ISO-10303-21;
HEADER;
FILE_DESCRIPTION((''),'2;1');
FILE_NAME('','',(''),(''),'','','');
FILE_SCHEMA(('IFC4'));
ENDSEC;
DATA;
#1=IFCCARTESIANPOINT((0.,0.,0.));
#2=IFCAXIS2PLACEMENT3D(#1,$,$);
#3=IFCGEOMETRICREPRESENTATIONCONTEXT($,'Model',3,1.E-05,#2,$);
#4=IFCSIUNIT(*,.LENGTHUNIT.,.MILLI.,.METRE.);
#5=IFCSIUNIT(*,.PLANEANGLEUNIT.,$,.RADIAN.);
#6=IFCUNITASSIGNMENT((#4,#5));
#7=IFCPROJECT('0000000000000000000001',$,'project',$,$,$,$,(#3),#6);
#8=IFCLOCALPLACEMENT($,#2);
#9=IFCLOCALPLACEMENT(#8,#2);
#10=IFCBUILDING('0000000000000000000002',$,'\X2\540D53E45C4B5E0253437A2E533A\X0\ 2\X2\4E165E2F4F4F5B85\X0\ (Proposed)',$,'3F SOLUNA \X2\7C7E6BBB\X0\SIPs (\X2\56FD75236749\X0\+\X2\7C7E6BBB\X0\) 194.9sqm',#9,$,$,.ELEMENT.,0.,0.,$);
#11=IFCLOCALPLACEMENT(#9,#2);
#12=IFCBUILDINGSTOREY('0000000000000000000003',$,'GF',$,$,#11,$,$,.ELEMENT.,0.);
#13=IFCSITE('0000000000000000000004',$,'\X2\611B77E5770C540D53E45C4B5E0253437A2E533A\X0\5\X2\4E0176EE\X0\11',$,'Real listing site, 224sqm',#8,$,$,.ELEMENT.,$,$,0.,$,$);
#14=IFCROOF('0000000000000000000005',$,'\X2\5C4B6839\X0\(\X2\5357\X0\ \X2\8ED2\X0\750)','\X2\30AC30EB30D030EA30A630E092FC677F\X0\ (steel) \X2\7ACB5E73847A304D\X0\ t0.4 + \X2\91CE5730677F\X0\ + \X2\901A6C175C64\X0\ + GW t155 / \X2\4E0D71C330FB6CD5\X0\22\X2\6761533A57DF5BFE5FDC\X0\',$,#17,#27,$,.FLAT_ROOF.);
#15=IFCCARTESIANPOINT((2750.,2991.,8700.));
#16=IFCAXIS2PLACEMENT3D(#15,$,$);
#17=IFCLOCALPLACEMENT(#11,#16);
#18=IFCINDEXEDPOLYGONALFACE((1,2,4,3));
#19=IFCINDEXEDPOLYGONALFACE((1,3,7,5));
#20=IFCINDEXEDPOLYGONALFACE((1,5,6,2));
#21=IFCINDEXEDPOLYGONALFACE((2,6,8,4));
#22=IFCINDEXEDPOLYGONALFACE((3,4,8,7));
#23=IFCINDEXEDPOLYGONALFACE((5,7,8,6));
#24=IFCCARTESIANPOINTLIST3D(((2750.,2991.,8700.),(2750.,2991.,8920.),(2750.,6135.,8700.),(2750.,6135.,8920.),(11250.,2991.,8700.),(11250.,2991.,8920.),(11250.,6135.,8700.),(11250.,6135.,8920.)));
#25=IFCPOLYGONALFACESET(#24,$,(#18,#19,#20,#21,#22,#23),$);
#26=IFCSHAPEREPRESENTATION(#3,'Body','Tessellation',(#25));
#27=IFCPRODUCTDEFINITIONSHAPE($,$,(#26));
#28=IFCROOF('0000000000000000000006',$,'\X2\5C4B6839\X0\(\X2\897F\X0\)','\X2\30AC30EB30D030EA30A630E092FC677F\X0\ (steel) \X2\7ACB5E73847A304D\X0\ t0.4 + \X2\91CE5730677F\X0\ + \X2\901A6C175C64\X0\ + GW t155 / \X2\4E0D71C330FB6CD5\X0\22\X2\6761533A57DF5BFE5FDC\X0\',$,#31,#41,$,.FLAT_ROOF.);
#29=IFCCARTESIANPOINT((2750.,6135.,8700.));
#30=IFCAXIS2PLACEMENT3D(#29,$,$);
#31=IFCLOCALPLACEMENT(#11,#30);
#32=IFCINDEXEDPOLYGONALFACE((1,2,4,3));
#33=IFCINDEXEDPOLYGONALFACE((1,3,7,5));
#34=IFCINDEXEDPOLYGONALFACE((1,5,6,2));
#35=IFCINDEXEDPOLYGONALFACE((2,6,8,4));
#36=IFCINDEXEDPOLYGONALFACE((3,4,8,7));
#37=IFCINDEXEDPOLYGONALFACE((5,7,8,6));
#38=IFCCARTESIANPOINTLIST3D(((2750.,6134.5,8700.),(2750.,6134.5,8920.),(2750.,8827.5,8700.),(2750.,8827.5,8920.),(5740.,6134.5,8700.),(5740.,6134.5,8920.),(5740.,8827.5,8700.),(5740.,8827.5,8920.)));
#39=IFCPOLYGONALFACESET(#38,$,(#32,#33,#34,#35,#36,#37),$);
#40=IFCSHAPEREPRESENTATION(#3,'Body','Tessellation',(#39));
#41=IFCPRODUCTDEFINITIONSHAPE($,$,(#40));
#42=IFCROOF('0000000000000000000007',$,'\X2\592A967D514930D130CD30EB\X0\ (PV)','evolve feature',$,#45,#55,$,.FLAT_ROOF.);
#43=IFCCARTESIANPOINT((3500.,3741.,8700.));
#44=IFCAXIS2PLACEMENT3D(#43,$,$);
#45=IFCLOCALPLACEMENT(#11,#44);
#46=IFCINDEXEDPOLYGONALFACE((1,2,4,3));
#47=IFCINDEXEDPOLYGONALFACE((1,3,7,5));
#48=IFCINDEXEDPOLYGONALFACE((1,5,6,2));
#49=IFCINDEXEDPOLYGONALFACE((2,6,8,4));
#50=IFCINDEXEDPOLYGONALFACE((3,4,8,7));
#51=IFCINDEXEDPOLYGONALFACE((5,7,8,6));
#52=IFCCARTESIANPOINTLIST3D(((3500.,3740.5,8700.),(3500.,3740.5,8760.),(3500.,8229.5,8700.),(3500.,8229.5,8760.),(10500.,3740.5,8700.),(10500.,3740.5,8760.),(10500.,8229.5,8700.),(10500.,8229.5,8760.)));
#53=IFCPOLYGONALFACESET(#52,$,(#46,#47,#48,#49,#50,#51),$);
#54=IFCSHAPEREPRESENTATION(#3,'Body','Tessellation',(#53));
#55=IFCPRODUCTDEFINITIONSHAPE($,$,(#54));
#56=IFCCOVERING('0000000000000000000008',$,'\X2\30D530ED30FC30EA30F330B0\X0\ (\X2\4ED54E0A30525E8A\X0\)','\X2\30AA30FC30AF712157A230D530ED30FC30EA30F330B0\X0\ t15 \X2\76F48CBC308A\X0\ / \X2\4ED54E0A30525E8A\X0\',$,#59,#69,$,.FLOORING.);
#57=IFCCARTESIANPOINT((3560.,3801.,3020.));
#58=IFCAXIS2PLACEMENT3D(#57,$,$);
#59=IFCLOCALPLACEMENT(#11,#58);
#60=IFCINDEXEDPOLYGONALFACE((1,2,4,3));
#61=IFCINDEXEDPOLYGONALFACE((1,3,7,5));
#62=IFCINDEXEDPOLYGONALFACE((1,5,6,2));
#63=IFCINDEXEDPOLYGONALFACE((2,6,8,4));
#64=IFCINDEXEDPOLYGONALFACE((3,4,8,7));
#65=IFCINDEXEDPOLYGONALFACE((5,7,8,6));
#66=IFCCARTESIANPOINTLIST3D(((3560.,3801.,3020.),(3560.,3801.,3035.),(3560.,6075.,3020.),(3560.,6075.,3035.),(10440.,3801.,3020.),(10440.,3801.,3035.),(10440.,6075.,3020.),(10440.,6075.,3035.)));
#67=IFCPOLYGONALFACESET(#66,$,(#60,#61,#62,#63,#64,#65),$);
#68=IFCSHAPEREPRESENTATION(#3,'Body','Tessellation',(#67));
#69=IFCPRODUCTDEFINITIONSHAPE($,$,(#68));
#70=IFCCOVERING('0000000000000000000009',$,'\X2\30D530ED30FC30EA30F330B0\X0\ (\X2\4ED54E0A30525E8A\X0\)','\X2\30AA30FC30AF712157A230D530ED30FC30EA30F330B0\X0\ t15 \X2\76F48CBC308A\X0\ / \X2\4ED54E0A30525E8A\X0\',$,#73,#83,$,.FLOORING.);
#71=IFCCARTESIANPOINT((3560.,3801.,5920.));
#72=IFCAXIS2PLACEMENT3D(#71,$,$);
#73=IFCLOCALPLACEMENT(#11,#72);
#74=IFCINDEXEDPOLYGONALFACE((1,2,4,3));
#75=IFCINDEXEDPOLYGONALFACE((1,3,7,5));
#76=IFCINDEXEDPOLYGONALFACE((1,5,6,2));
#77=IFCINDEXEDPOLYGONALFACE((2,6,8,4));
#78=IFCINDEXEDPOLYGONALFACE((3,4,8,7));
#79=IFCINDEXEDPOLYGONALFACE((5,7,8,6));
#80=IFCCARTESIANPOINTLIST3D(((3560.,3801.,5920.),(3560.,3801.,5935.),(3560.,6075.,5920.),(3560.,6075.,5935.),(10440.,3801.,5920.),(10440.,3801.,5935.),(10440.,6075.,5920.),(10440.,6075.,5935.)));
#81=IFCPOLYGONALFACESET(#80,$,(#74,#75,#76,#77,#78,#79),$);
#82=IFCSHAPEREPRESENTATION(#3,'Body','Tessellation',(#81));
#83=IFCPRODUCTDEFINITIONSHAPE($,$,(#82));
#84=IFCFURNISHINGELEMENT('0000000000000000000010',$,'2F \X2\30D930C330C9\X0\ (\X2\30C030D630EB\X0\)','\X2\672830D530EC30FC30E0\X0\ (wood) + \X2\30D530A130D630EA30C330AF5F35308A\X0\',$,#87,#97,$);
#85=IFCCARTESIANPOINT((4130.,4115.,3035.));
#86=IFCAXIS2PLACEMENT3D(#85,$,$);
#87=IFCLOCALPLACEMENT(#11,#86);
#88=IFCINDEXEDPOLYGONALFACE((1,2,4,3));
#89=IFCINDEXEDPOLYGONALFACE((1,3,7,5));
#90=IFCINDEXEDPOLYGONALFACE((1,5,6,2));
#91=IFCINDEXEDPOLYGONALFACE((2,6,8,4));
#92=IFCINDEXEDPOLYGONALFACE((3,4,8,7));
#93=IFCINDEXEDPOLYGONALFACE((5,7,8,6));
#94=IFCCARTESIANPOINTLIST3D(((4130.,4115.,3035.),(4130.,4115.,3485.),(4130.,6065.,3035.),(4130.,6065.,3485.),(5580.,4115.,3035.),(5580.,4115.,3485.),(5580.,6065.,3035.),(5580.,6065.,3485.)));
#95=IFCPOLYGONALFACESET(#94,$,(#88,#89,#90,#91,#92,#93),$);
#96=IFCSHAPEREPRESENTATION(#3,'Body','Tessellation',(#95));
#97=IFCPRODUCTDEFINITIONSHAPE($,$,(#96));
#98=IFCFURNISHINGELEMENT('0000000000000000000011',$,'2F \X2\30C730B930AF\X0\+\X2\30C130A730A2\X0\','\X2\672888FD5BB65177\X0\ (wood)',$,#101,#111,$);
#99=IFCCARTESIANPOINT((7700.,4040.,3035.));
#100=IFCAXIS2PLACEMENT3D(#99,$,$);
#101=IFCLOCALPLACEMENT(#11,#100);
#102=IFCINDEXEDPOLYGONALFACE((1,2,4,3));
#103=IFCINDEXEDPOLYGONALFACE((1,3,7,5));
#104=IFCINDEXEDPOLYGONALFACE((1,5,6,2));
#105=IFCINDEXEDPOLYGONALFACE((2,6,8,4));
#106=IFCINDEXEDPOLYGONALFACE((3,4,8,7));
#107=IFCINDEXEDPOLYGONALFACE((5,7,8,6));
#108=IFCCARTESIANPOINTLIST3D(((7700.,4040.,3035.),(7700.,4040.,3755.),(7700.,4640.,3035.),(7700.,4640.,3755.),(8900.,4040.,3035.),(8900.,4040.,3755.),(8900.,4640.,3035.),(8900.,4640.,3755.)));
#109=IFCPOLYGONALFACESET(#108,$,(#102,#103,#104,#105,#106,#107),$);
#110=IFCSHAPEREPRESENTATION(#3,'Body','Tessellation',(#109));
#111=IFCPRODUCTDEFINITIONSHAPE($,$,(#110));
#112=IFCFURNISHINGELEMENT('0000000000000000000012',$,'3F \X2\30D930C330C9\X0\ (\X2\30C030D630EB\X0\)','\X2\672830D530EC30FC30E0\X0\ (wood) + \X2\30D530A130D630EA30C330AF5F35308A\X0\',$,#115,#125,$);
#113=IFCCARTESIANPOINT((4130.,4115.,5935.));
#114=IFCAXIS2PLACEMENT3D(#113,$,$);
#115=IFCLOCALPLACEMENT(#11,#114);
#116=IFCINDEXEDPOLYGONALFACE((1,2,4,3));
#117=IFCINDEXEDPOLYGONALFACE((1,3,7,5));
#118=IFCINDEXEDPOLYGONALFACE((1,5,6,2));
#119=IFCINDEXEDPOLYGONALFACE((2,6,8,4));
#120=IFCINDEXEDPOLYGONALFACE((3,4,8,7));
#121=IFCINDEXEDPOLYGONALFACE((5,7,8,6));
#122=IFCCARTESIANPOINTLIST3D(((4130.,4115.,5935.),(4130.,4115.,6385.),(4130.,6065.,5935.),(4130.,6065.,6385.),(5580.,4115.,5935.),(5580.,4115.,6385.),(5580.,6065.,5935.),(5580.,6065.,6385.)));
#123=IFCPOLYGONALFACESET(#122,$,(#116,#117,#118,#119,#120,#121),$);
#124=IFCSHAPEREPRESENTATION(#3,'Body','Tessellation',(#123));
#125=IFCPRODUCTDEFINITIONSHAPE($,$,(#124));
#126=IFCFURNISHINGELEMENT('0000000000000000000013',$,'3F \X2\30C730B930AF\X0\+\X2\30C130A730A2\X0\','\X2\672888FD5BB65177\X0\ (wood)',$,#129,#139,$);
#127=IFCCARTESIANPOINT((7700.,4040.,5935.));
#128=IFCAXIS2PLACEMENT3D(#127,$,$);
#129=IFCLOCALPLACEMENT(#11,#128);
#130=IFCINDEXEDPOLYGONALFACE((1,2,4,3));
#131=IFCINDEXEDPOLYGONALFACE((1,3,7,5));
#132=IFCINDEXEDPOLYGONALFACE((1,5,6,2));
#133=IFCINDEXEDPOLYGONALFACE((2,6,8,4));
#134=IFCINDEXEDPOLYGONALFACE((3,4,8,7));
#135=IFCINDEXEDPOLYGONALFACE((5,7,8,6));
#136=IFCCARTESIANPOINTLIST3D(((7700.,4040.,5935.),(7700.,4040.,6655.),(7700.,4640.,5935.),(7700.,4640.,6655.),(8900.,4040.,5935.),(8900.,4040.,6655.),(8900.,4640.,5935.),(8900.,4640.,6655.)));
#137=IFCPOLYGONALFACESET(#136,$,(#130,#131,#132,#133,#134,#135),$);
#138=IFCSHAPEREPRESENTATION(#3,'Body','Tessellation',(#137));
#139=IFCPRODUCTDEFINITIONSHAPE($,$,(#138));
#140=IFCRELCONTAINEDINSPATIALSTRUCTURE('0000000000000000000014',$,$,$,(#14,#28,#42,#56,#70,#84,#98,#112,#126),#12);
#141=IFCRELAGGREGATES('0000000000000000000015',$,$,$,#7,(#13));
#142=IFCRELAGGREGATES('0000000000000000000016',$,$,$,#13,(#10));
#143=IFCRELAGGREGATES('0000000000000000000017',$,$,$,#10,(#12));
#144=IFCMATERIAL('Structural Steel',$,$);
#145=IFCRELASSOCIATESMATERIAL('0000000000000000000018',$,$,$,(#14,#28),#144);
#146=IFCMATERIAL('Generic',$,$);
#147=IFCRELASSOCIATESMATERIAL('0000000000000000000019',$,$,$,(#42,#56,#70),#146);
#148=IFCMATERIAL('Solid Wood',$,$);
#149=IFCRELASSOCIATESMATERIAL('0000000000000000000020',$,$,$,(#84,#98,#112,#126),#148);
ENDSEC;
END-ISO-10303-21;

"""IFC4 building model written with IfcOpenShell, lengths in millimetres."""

from ifc_helpers import new_model, si_unit, frame, frame_2d, origin, place, context, project, spatial, rectangle, extrude, material, element, save


model = new_model("IFC4")

# Units and contexts
model_context = context("Model", 3, precision=1e-05, world=origin())
ifc_project = project(units=[si_unit("LENGTHUNIT", "METRE", prefix="MILLI"), si_unit("PLANEANGLEUNIT", "RADIAN")], contexts=[model_context])

# Site, building, storey
site_placement = place(None, origin())
site = spatial("IfcSite", under=ifc_project, at=site_placement, Name="愛知県名古屋市千種区5丁目11", ObjectType="Real listing site, 224sqm", CompositionType="ELEMENT", RefElevation=0.0)
building_placement = place(site_placement, origin())
building = spatial("IfcBuilding", under=site, at=building_placement, Name="名古屋市千種区 2世帯住宅 (Proposed)", ObjectType="3F SOLUNA 籾殻SIPs (国産杉+籾殻) 194.9sqm", CompositionType="ELEMENT", ElevationOfRefHeight=0.0, ElevationOfTerrain=0.0)
storey_placement = place(building_placement, origin())
storey = spatial("IfcBuildingStorey", under=building, at=storey_placement, Name="GF", CompositionType="ELEMENT", Elevation=0.0)

# Shared definitions
ifc_material_1 = material(Name="Solid Wood")

# Roofs
ifc_material_2 = material(Name="Structural Steel")
roof_1_placement = place(storey_placement, frame((2750.0, 2991.0, 8700.0)))
element("IfcRoof", 1, at=roof_1_placement, inside=storey, material=ifc_material_2, Name="屋根(南 軒750)", Description="ガルバリウム鋼板 (steel) 立平葺き t0.4 + 野地板 + 通気層 + GW t155 / 不燃・法22条区域対応", PredefinedType="FLAT_ROOF", context=model_context, shape_type="SweptSolid", body=[
    extrude(rectangle(XDim=8500.0, YDim=3144.0, at=frame_2d((4250.0, 1572.0))), frame((2750.0, 2991.0, 8700.0)), (0.0, 0.0, 1.0), 220.0),
])
roof_2_placement = place(storey_placement, frame((2750.0, 6135.0, 8700.0)))
element("IfcRoof", 2, at=roof_2_placement, inside=storey, material=ifc_material_2, Name="屋根(西)", Description="ガルバリウム鋼板 (steel) 立平葺き t0.4 + 野地板 + 通気層 + GW t155 / 不燃・法22条区域対応", PredefinedType="FLAT_ROOF", context=model_context, shape_type="SweptSolid", body=[
    extrude(rectangle(XDim=2990.0, YDim=2693.0, at=frame_2d((1495.0, 1346.0))), frame((2750.0, 6135.0, 8700.0)), (0.0, 0.0, 1.0), 220.0),
])
ifc_material_3 = material(Name="Generic")
roof_3_placement = place(storey_placement, frame((3500.0, 3741.0, 8700.0)))
element("IfcRoof", 3, at=roof_3_placement, inside=storey, material=ifc_material_3, Name="太陽光パネル (PV)", Description="evolve feature", PredefinedType="FLAT_ROOF", context=model_context, shape_type="SweptSolid", body=[
    extrude(rectangle(XDim=7000.0, YDim=4489.0, at=frame_2d((3500.0, 2244.0))), frame((3500.0, 3741.0, 8700.0)), (0.0, 0.0, 1.0), 60.0),
])

# Coverings
covering_1_placement = place(storey_placement, frame((3560.0, 3801.0, 3020.0)))
element("IfcCovering", 4, at=covering_1_placement, inside=storey, material=ifc_material_3, Name="フローリング (仕上げ床)", Description="オーク無垢フローリング t15 直貼り / 仕上げ床", PredefinedType="FLOORING", context=model_context, shape_type="SweptSolid", body=[
    extrude(rectangle(XDim=6880.0, YDim=2274.0, at=frame_2d((3440.0, 1137.0))), frame((3560.0, 3801.0, 3020.0)), (0.0, 0.0, 1.0), 15.0),
])
covering_2_placement = place(storey_placement, frame((3560.0, 3801.0, 5920.0)))
element("IfcCovering", 5, at=covering_2_placement, inside=storey, material=ifc_material_3, Name="フローリング (仕上げ床)", Description="オーク無垢フローリング t15 直貼り / 仕上げ床", PredefinedType="FLOORING", context=model_context, shape_type="SweptSolid", body=[
    extrude(rectangle(XDim=6880.0, YDim=2274.0, at=frame_2d((3440.0, 1137.0))), frame((3560.0, 3801.0, 5920.0)), (0.0, 0.0, 1.0), 15.0),
])

# Furnishing elements
furnishing_1_placement = place(storey_placement, frame((4130.0, 4115.0, 3035.0)))
element("IfcFurnishingElement", 6, at=furnishing_1_placement, inside=storey, material=ifc_material_1, Name="2F ベッド (ダブル)", Description="木フレーム (wood) + ファブリック張り", context=model_context, shape_type="SweptSolid", body=[
    extrude(rectangle(XDim=1450.0, YDim=1950.0, at=frame_2d((725.0, 975.0))), frame((4130.0, 4115.0, 3035.0)), (0.0, 0.0, 1.0), 450.0),
])
furnishing_2_placement = place(storey_placement, frame((7700.0, 4040.0, 3035.0)))
element("IfcFurnishingElement", 7, at=furnishing_2_placement, inside=storey, material=ifc_material_1, Name="2F デスク+チェア", Description="木製家具 (wood)", context=model_context, shape_type="SweptSolid", body=[
    extrude(rectangle(XDim=1200.0, YDim=600.0, at=frame_2d((600.0, 300.0))), frame((7700.0, 4040.0, 3035.0)), (0.0, 0.0, 1.0), 720.0),
])
furnishing_3_placement = place(storey_placement, frame((4130.0, 4115.0, 5935.0)))
element("IfcFurnishingElement", 8, at=furnishing_3_placement, inside=storey, material=ifc_material_1, Name="3F ベッド (ダブル)", Description="木フレーム (wood) + ファブリック張り", context=model_context, shape_type="SweptSolid", body=[
    extrude(rectangle(XDim=1450.0, YDim=1950.0, at=frame_2d((725.0, 975.0))), frame((4130.0, 4115.0, 5935.0)), (0.0, 0.0, 1.0), 450.0),
])
furnishing_4_placement = place(storey_placement, frame((7700.0, 4040.0, 5935.0)))
element("IfcFurnishingElement", 9, at=furnishing_4_placement, inside=storey, material=ifc_material_1, Name="3F デスク+チェア", Description="木製家具 (wood)", context=model_context, shape_type="SweptSolid", body=[
    extrude(rectangle(XDim=1200.0, YDim=600.0, at=frame_2d((600.0, 300.0))), frame((7700.0, 4040.0, 5935.0)), (0.0, 0.0, 1.0), 720.0),
])

save(model, "model.ifc")
